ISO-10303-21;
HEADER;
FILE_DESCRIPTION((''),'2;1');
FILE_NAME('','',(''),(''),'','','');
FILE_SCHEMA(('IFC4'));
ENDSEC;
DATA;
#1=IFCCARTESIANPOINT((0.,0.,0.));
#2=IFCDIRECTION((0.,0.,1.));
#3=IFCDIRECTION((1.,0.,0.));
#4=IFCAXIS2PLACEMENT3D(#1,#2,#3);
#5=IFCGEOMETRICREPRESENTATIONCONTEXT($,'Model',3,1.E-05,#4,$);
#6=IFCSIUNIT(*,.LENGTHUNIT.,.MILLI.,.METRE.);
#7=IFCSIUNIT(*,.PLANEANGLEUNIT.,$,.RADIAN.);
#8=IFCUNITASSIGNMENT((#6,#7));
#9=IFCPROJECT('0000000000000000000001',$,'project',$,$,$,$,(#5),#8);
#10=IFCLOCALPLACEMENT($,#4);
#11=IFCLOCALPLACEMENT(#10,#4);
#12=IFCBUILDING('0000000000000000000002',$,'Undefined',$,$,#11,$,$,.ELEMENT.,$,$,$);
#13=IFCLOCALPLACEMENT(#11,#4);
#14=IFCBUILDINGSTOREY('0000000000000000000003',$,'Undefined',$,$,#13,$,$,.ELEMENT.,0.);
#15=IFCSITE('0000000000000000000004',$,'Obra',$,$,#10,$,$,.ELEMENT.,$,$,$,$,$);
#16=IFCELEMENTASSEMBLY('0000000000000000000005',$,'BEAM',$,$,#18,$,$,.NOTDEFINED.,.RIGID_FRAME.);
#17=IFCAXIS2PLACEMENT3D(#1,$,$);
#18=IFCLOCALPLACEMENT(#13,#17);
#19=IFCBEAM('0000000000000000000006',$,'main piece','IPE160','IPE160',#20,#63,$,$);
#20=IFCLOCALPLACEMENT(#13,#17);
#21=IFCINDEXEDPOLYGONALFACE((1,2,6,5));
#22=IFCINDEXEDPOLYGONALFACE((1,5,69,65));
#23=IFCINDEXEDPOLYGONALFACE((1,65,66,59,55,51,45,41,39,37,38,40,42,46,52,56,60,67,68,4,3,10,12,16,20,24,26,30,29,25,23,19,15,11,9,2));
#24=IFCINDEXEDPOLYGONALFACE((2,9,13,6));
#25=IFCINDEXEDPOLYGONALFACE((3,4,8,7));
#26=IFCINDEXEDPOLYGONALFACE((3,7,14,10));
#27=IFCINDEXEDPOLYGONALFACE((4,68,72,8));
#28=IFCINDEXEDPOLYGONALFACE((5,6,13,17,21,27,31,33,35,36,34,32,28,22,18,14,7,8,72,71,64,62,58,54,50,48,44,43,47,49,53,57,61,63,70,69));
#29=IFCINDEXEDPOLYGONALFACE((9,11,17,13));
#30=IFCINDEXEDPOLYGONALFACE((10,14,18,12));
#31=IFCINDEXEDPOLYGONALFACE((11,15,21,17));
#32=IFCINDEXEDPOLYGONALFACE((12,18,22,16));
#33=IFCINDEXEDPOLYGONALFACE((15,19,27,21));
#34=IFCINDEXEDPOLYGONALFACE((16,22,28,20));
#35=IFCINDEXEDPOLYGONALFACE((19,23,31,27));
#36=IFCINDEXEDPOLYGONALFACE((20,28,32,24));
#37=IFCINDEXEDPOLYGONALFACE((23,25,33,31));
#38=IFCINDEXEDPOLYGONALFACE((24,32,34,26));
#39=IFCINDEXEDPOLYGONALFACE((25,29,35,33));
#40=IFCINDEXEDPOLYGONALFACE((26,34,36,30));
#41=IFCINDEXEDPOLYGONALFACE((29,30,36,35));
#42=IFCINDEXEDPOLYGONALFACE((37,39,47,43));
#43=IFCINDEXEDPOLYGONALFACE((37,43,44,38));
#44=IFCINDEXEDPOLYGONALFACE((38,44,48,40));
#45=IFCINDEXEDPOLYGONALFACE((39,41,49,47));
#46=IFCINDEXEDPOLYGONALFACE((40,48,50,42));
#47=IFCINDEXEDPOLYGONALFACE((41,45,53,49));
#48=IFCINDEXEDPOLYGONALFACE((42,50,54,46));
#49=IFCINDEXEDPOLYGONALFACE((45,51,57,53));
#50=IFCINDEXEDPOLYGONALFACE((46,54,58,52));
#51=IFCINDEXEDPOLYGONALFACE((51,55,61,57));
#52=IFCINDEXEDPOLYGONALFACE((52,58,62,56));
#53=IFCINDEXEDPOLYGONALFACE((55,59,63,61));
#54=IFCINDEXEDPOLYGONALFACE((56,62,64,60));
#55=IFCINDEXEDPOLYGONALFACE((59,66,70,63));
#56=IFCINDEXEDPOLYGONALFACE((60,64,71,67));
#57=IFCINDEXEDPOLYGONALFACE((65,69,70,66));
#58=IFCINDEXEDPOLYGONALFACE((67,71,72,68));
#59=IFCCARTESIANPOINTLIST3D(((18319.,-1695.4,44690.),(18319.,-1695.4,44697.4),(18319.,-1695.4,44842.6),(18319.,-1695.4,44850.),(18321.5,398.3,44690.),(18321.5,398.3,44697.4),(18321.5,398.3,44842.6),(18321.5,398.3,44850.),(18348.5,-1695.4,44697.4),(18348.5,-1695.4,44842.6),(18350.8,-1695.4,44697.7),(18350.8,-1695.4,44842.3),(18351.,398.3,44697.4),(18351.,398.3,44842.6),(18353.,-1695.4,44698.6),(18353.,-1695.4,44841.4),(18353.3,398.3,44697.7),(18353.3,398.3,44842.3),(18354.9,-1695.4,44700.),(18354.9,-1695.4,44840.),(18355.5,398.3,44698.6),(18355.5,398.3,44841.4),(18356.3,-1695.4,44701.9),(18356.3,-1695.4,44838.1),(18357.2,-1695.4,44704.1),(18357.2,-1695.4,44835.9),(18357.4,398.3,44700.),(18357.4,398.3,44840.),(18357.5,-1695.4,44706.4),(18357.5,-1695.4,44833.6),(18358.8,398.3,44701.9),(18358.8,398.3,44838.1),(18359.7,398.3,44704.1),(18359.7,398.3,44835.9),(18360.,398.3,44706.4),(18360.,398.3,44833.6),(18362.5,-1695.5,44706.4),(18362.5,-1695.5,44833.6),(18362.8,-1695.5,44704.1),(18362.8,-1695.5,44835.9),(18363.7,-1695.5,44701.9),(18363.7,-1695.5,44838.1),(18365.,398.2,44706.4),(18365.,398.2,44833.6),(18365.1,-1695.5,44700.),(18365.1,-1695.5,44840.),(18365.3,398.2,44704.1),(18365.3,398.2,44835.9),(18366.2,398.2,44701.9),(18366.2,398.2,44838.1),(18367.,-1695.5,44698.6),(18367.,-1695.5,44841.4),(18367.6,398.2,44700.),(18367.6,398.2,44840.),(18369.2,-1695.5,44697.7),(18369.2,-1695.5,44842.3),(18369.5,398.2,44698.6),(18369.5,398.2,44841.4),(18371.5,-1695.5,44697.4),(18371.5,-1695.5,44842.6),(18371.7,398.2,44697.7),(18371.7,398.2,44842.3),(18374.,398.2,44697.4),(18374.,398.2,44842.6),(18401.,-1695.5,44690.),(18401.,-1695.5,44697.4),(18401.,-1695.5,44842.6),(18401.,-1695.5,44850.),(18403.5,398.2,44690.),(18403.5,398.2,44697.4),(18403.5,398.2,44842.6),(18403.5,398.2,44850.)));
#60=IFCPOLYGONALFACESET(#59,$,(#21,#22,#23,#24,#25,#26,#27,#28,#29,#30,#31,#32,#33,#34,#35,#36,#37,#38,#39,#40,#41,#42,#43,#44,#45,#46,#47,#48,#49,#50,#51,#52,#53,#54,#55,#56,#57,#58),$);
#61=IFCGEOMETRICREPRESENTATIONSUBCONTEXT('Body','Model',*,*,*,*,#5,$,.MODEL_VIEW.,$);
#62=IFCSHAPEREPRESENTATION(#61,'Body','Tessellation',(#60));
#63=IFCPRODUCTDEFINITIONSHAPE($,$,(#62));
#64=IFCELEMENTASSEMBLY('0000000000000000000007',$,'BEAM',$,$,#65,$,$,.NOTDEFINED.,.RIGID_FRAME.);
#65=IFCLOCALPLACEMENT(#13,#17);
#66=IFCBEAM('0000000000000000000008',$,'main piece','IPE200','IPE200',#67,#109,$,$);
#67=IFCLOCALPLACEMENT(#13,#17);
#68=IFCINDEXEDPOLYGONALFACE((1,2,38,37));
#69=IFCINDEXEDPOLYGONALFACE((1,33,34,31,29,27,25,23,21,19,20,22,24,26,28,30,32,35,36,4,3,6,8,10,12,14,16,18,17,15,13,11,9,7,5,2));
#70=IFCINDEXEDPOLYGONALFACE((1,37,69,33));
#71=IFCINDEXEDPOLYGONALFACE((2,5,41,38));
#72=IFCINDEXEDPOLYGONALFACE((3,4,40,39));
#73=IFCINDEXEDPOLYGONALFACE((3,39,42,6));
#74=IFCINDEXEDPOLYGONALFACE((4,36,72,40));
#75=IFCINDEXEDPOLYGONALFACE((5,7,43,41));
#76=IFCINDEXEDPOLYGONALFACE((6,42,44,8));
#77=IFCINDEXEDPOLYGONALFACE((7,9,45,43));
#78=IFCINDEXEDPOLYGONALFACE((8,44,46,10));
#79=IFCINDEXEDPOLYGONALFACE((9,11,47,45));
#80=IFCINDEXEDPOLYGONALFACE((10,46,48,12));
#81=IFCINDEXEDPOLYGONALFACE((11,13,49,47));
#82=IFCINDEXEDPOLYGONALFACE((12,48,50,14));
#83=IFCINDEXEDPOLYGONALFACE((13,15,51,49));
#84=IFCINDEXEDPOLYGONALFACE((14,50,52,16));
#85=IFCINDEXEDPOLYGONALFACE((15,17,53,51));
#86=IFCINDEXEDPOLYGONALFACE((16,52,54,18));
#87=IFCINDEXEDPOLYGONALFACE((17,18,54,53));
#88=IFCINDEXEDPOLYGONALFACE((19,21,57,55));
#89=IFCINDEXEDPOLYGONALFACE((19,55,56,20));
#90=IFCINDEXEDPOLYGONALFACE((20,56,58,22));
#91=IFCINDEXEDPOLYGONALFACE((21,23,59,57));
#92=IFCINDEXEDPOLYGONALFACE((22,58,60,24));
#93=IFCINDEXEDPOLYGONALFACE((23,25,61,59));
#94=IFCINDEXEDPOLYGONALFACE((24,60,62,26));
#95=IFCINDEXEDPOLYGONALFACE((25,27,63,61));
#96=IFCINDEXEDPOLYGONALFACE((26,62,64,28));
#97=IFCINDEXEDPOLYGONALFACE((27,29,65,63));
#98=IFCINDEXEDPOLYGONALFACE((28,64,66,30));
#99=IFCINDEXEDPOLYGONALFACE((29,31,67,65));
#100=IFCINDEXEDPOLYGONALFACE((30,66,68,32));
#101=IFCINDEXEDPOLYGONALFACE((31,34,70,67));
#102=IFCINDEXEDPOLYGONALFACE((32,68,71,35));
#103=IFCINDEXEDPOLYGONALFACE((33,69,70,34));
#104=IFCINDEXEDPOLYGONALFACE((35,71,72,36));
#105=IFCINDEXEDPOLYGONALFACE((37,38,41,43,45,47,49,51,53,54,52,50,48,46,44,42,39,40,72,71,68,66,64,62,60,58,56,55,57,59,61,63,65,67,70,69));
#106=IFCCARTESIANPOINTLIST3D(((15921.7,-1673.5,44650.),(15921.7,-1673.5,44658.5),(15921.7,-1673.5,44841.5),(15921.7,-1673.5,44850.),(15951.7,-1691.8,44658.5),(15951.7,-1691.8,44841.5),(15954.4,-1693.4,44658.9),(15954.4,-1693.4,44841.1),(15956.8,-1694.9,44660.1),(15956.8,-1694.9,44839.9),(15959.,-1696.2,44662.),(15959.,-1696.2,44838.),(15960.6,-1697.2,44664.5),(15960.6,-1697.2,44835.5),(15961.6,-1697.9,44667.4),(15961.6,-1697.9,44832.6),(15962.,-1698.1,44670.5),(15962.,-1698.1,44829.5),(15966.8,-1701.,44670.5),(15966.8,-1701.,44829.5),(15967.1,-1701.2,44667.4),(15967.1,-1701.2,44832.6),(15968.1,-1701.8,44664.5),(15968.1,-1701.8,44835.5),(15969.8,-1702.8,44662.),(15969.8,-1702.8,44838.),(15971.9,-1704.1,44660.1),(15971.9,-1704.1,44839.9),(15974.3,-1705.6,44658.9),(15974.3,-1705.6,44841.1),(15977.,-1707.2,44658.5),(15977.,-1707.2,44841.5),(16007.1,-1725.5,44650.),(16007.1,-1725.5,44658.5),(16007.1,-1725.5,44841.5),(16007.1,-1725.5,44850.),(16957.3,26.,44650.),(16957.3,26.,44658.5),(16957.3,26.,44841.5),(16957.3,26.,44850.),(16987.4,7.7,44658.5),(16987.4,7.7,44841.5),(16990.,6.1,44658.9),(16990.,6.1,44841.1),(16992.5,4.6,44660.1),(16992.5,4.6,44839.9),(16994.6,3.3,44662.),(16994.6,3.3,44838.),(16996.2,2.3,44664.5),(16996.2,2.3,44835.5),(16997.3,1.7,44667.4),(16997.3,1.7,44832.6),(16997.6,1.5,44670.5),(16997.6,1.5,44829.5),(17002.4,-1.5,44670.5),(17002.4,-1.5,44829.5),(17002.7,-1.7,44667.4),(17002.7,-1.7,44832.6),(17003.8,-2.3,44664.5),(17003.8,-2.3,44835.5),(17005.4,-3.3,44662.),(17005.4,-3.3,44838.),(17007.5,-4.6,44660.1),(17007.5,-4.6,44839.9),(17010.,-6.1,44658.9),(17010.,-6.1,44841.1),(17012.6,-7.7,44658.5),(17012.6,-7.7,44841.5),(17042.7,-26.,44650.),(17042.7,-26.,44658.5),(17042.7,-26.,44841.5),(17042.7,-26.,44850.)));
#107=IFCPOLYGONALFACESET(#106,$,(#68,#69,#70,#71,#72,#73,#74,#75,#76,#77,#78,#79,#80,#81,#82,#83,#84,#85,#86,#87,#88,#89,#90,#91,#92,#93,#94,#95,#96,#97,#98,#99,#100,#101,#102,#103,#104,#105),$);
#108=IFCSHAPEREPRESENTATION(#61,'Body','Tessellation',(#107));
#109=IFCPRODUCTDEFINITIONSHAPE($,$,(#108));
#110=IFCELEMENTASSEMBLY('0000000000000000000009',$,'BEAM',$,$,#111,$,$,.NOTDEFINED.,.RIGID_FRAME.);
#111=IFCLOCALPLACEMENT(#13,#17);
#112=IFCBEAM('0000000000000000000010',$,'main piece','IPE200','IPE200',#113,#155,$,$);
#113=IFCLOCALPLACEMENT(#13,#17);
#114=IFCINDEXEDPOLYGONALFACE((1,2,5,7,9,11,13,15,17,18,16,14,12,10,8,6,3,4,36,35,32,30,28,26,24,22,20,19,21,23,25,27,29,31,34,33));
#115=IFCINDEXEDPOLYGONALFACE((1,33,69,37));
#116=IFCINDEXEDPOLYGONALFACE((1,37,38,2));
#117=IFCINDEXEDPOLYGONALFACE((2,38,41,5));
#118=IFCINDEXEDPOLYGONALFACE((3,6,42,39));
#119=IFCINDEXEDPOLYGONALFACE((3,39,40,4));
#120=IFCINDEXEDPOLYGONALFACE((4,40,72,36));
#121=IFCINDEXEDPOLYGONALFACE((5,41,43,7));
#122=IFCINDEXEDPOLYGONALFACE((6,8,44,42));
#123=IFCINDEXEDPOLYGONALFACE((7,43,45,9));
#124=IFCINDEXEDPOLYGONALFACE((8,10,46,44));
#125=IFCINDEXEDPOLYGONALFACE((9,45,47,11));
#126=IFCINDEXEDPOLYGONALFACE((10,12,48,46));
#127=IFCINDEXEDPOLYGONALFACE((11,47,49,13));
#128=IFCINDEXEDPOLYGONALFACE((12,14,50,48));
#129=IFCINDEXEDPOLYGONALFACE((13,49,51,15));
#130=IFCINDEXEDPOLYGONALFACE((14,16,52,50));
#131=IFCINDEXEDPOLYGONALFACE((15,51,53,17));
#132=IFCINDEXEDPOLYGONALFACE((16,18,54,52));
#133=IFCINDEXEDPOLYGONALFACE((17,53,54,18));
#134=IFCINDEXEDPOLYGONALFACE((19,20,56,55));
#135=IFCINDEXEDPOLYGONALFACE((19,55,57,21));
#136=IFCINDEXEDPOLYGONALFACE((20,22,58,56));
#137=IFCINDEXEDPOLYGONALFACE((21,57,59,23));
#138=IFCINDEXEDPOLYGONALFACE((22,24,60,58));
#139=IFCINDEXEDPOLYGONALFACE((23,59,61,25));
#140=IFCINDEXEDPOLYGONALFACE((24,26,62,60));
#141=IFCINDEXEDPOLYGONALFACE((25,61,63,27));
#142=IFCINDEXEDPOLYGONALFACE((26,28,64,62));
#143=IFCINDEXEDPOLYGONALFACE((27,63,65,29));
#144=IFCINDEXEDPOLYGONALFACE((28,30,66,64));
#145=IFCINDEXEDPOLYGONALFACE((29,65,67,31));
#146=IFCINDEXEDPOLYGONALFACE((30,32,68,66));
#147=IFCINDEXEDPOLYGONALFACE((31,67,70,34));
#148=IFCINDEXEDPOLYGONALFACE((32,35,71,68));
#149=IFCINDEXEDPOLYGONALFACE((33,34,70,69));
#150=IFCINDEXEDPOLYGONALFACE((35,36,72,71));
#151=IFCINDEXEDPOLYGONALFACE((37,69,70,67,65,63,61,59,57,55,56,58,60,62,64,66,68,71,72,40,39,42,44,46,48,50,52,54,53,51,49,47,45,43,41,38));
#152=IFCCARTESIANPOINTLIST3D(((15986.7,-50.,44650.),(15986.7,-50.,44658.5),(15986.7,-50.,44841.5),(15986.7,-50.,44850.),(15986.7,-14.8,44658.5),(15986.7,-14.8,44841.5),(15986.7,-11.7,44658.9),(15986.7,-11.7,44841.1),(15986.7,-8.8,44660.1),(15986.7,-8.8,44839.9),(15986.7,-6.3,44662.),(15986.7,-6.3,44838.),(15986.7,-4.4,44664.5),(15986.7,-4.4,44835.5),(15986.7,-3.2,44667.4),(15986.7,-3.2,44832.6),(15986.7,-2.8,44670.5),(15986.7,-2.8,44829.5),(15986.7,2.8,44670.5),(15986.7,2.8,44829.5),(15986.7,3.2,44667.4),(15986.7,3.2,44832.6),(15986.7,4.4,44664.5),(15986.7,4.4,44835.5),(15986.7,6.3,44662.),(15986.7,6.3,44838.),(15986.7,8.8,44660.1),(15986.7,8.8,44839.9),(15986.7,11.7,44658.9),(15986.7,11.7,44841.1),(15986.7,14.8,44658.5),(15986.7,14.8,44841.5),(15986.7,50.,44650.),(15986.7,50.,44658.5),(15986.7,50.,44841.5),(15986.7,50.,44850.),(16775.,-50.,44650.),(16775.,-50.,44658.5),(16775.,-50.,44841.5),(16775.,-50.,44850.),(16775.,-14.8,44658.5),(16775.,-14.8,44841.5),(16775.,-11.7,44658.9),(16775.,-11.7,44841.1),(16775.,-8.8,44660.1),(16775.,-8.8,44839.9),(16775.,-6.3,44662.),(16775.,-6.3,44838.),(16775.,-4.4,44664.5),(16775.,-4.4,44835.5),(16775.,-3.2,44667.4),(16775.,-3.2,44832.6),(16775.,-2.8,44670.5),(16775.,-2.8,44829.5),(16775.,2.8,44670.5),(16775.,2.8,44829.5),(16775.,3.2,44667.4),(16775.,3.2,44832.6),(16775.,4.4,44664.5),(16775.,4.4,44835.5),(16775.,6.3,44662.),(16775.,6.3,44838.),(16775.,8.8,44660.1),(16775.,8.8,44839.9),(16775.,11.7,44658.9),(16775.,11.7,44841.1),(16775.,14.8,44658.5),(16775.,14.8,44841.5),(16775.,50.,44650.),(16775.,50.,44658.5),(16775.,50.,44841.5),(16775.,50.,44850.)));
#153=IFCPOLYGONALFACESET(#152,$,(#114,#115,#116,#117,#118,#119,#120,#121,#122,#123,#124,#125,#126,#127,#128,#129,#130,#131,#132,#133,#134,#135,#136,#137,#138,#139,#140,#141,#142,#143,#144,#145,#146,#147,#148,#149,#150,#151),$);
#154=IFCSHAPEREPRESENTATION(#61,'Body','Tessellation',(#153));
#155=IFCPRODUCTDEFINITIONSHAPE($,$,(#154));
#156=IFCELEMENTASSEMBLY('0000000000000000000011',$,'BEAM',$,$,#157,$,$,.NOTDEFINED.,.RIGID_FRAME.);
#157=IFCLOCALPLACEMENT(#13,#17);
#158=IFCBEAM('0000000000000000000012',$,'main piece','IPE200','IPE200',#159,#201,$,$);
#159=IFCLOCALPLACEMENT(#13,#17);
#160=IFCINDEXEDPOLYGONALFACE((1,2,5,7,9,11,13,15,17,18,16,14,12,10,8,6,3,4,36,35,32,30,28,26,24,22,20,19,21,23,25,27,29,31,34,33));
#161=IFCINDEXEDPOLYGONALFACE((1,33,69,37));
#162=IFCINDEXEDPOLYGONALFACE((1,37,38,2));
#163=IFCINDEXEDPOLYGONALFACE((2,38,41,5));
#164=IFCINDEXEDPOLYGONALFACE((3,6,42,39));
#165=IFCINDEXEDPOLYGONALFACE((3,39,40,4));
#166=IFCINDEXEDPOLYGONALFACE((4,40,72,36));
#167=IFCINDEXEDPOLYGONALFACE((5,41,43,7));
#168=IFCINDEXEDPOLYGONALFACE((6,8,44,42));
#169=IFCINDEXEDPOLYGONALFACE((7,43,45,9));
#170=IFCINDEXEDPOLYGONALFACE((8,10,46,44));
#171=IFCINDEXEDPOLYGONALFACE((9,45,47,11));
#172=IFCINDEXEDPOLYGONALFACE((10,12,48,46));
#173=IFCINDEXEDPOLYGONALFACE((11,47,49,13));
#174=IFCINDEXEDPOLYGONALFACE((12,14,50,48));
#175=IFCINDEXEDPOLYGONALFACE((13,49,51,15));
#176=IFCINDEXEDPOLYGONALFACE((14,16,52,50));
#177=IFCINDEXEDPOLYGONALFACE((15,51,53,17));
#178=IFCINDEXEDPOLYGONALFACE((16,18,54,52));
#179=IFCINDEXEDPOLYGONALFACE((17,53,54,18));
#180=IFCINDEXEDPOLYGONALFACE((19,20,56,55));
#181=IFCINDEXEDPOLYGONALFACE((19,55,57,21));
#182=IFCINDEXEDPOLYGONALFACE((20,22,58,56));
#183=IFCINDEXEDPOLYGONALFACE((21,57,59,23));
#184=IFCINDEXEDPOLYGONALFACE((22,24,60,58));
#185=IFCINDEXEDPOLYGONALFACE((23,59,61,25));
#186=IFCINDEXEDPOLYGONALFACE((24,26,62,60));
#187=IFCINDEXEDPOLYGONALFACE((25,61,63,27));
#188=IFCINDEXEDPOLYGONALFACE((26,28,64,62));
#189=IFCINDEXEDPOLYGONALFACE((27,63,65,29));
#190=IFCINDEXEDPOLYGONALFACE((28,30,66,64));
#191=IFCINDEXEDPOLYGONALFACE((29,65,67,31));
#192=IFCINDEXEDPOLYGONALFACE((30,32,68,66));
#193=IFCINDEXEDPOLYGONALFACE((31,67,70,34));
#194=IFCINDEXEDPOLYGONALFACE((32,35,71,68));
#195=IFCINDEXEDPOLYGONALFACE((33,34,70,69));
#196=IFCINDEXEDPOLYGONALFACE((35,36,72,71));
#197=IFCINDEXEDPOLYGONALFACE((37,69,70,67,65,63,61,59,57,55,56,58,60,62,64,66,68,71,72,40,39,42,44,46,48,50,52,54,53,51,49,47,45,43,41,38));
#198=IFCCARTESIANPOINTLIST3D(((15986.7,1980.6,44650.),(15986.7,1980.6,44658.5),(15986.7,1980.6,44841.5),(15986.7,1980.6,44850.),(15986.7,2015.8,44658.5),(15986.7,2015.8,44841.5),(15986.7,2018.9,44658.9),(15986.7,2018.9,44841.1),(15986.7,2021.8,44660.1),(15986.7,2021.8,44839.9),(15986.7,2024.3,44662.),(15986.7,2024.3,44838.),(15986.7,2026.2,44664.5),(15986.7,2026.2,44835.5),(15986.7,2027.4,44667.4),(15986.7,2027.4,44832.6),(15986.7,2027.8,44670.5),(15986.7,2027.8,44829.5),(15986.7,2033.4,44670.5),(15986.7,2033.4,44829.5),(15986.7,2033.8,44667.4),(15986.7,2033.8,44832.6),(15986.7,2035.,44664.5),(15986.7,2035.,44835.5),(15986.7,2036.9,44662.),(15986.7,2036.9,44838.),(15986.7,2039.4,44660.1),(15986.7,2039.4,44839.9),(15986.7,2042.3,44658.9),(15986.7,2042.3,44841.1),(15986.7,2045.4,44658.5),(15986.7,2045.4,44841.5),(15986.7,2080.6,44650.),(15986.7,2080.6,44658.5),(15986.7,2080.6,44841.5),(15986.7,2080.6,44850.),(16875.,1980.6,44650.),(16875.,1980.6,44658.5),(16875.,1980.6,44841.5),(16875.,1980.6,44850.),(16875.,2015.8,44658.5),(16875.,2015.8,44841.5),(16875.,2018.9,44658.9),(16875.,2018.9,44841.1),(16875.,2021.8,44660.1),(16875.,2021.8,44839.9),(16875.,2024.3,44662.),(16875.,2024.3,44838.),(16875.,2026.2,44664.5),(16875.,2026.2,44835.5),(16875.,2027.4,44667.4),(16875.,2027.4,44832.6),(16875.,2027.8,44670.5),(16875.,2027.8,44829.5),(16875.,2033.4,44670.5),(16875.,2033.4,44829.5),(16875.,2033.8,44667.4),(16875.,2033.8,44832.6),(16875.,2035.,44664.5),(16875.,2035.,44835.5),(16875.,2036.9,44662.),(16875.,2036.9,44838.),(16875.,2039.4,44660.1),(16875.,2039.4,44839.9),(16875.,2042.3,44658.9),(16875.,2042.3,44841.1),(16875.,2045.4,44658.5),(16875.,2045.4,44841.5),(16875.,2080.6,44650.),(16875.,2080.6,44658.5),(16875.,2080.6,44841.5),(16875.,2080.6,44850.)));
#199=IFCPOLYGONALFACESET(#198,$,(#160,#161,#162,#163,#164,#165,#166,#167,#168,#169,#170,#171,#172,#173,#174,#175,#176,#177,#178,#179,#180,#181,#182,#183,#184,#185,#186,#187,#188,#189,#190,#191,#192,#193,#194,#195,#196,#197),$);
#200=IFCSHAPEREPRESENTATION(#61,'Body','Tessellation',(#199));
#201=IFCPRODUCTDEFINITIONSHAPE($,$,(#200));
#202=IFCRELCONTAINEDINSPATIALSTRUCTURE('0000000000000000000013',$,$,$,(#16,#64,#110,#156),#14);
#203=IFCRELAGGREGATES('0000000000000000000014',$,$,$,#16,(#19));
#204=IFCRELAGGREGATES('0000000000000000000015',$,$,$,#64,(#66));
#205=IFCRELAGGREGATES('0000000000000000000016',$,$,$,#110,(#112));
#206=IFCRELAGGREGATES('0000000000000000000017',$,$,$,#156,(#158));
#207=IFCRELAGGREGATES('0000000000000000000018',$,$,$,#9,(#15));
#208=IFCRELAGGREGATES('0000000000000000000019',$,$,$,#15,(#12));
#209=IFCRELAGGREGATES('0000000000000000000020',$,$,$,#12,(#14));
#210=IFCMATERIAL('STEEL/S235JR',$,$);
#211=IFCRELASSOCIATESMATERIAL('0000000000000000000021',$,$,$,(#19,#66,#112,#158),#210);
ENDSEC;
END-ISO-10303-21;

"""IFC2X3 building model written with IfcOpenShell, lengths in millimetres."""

from ifc_helpers import new_model, si_unit, frame, origin_with_axes, origin_2d_with_axis, place, context, subcontext, project, spatial, i_section, extrude, material, element, aggregate, save


model = new_model("IFC2X3")

# Units and contexts
model_context = context("Model", 3, precision=1e-05, world=origin_with_axes())
body_context = subcontext(model_context, "Body", "Model", "MODEL_VIEW")
ifc_project = project(units=[si_unit("LENGTHUNIT", "METRE", prefix="MILLI"), si_unit("PLANEANGLEUNIT", "RADIAN")], contexts=[model_context])

# Site, building, storey
site_placement = place(None, origin_with_axes())
site = spatial("IfcSite", under=ifc_project, at=site_placement, Name="Obra", CompositionType="ELEMENT")
building_placement = place(site_placement, origin_with_axes())
building = spatial("IfcBuilding", under=site, at=building_placement, Name="Undefined", CompositionType="ELEMENT")
storey_placement = place(building_placement, origin_with_axes())
storey = spatial("IfcBuildingStorey", under=building, at=storey_placement, Name="Undefined", CompositionType="ELEMENT", Elevation=0.0)

# Shared definitions
ifc_material = material(Name="STEEL/S235JR")

# Element assemblies, beams
assembly_1_placement = place(storey_placement, origin_with_axes())
assembly_1 = element("IfcElementAssembly", 1, at=assembly_1_placement, inside=storey, Name="BEAM", AssemblyPlace="NOTDEFINED", PredefinedType="RIGID_FRAME")
beam_1_placement = place(assembly_1_placement, frame((18360.0, -1695.5, 44770.0), z_axis=(0.0, 0.0, 1.0), x_axis=(0.001194, 0.999999, 0.0)))
beam_1 = element("IfcBeam", 2, at=beam_1_placement, material=ifc_material, Name="main piece", Description="IPE160", ObjectType="IPE160", context=body_context, shape_type="SweptSolid", body=[
    extrude(i_section(OverallWidth=82.0, OverallDepth=160.0, WebThickness=5.0, FlangeThickness=7.4, FilletRadius=9.0, at=origin_2d_with_axis()), frame((2093.7, 0.0, 0.0), z_axis=(-1.0, 0.0, 0.0), x_axis=(0.0, -1.0, 0.0)), (0.0, 0.0, 1.0), 2093.7),
])
aggregate(assembly_1, [beam_1])
assembly_2_placement = place(storey_placement, origin_with_axes())
assembly_2 = element("IfcElementAssembly", 3, at=assembly_2_placement, inside=storey, Name="BEAM", AssemblyPlace="NOTDEFINED", PredefinedType="RIGID_FRAME")
beam_2_placement = place(assembly_2_placement, frame((17000.0, 0.0, 44750.0), z_axis=(0.0, 0.0, 1.0), x_axis=(-0.520368, -0.853942, 0.0)))
beam_2 = element("IfcBeam", 4, at=beam_2_placement, material=ifc_material, Name="main piece", Description="IPE200", ObjectType="IPE200", context=body_context, shape_type="SweptSolid", body=[
    extrude(i_section(OverallWidth=100.0, OverallDepth=200.0, WebThickness=5.6, FlangeThickness=8.5, FilletRadius=12.0, at=origin_2d_with_axis()), frame((1990.2, 0.0, 0.0), z_axis=(-1.0, 0.0, 0.0), x_axis=(0.0, -1.0, 0.0)), (0.0, 0.0, 1.0), 1990.2),
])
aggregate(assembly_2, [beam_2])
assembly_3_placement = place(storey_placement, origin_with_axes())
assembly_3 = element("IfcElementAssembly", 5, at=assembly_3_placement, inside=storey, Name="BEAM", AssemblyPlace="NOTDEFINED", PredefinedType="RIGID_FRAME")
beam_3_placement = place(assembly_3_placement, frame((16775.0, 0.0, 44750.0), z_axis=(0.0, 0.0, 1.0), x_axis=(-1.0, 0.0, 0.0)))
beam_3 = element("IfcBeam", 6, at=beam_3_placement, material=ifc_material, Name="main piece", Description="IPE200", ObjectType="IPE200", context=body_context, shape_type="SweptSolid", body=[
    extrude(i_section(OverallWidth=100.0, OverallDepth=200.0, WebThickness=5.6, FlangeThickness=8.5, FilletRadius=12.0, at=origin_2d_with_axis()), frame((788.3, 0.0, 0.0), z_axis=(-1.0, 0.0, 0.0), x_axis=(0.0, -1.0, 0.0)), (0.0, 0.0, 1.0), 788.3),
])
aggregate(assembly_3, [beam_3])
assembly_4_placement = place(storey_placement, origin_with_axes())
assembly_4 = element("IfcElementAssembly", 7, at=assembly_4_placement, inside=storey, Name="BEAM", AssemblyPlace="NOTDEFINED", PredefinedType="RIGID_FRAME")
beam_4_placement = place(assembly_4_placement, frame((16875.0, 2030.6, 44750.0), z_axis=(0.0, 0.0, 1.0), x_axis=(-1.0, 0.0, 0.0)))
beam_4 = element("IfcBeam", 8, at=beam_4_placement, material=ifc_material, Name="main piece", Description="IPE200", ObjectType="IPE200", context=body_context, shape_type="SweptSolid", body=[
    extrude(i_section(OverallWidth=100.0, OverallDepth=200.0, WebThickness=5.6, FlangeThickness=8.5, FilletRadius=12.0, at=origin_2d_with_axis()), frame((888.3, 0.0, 0.0), z_axis=(-1.0, 0.0, 0.0), x_axis=(0.0, -1.0, 0.0)), (0.0, 0.0, 1.0), 888.3),
])
aggregate(assembly_4, [beam_4])

save(model, "model.ifc")
